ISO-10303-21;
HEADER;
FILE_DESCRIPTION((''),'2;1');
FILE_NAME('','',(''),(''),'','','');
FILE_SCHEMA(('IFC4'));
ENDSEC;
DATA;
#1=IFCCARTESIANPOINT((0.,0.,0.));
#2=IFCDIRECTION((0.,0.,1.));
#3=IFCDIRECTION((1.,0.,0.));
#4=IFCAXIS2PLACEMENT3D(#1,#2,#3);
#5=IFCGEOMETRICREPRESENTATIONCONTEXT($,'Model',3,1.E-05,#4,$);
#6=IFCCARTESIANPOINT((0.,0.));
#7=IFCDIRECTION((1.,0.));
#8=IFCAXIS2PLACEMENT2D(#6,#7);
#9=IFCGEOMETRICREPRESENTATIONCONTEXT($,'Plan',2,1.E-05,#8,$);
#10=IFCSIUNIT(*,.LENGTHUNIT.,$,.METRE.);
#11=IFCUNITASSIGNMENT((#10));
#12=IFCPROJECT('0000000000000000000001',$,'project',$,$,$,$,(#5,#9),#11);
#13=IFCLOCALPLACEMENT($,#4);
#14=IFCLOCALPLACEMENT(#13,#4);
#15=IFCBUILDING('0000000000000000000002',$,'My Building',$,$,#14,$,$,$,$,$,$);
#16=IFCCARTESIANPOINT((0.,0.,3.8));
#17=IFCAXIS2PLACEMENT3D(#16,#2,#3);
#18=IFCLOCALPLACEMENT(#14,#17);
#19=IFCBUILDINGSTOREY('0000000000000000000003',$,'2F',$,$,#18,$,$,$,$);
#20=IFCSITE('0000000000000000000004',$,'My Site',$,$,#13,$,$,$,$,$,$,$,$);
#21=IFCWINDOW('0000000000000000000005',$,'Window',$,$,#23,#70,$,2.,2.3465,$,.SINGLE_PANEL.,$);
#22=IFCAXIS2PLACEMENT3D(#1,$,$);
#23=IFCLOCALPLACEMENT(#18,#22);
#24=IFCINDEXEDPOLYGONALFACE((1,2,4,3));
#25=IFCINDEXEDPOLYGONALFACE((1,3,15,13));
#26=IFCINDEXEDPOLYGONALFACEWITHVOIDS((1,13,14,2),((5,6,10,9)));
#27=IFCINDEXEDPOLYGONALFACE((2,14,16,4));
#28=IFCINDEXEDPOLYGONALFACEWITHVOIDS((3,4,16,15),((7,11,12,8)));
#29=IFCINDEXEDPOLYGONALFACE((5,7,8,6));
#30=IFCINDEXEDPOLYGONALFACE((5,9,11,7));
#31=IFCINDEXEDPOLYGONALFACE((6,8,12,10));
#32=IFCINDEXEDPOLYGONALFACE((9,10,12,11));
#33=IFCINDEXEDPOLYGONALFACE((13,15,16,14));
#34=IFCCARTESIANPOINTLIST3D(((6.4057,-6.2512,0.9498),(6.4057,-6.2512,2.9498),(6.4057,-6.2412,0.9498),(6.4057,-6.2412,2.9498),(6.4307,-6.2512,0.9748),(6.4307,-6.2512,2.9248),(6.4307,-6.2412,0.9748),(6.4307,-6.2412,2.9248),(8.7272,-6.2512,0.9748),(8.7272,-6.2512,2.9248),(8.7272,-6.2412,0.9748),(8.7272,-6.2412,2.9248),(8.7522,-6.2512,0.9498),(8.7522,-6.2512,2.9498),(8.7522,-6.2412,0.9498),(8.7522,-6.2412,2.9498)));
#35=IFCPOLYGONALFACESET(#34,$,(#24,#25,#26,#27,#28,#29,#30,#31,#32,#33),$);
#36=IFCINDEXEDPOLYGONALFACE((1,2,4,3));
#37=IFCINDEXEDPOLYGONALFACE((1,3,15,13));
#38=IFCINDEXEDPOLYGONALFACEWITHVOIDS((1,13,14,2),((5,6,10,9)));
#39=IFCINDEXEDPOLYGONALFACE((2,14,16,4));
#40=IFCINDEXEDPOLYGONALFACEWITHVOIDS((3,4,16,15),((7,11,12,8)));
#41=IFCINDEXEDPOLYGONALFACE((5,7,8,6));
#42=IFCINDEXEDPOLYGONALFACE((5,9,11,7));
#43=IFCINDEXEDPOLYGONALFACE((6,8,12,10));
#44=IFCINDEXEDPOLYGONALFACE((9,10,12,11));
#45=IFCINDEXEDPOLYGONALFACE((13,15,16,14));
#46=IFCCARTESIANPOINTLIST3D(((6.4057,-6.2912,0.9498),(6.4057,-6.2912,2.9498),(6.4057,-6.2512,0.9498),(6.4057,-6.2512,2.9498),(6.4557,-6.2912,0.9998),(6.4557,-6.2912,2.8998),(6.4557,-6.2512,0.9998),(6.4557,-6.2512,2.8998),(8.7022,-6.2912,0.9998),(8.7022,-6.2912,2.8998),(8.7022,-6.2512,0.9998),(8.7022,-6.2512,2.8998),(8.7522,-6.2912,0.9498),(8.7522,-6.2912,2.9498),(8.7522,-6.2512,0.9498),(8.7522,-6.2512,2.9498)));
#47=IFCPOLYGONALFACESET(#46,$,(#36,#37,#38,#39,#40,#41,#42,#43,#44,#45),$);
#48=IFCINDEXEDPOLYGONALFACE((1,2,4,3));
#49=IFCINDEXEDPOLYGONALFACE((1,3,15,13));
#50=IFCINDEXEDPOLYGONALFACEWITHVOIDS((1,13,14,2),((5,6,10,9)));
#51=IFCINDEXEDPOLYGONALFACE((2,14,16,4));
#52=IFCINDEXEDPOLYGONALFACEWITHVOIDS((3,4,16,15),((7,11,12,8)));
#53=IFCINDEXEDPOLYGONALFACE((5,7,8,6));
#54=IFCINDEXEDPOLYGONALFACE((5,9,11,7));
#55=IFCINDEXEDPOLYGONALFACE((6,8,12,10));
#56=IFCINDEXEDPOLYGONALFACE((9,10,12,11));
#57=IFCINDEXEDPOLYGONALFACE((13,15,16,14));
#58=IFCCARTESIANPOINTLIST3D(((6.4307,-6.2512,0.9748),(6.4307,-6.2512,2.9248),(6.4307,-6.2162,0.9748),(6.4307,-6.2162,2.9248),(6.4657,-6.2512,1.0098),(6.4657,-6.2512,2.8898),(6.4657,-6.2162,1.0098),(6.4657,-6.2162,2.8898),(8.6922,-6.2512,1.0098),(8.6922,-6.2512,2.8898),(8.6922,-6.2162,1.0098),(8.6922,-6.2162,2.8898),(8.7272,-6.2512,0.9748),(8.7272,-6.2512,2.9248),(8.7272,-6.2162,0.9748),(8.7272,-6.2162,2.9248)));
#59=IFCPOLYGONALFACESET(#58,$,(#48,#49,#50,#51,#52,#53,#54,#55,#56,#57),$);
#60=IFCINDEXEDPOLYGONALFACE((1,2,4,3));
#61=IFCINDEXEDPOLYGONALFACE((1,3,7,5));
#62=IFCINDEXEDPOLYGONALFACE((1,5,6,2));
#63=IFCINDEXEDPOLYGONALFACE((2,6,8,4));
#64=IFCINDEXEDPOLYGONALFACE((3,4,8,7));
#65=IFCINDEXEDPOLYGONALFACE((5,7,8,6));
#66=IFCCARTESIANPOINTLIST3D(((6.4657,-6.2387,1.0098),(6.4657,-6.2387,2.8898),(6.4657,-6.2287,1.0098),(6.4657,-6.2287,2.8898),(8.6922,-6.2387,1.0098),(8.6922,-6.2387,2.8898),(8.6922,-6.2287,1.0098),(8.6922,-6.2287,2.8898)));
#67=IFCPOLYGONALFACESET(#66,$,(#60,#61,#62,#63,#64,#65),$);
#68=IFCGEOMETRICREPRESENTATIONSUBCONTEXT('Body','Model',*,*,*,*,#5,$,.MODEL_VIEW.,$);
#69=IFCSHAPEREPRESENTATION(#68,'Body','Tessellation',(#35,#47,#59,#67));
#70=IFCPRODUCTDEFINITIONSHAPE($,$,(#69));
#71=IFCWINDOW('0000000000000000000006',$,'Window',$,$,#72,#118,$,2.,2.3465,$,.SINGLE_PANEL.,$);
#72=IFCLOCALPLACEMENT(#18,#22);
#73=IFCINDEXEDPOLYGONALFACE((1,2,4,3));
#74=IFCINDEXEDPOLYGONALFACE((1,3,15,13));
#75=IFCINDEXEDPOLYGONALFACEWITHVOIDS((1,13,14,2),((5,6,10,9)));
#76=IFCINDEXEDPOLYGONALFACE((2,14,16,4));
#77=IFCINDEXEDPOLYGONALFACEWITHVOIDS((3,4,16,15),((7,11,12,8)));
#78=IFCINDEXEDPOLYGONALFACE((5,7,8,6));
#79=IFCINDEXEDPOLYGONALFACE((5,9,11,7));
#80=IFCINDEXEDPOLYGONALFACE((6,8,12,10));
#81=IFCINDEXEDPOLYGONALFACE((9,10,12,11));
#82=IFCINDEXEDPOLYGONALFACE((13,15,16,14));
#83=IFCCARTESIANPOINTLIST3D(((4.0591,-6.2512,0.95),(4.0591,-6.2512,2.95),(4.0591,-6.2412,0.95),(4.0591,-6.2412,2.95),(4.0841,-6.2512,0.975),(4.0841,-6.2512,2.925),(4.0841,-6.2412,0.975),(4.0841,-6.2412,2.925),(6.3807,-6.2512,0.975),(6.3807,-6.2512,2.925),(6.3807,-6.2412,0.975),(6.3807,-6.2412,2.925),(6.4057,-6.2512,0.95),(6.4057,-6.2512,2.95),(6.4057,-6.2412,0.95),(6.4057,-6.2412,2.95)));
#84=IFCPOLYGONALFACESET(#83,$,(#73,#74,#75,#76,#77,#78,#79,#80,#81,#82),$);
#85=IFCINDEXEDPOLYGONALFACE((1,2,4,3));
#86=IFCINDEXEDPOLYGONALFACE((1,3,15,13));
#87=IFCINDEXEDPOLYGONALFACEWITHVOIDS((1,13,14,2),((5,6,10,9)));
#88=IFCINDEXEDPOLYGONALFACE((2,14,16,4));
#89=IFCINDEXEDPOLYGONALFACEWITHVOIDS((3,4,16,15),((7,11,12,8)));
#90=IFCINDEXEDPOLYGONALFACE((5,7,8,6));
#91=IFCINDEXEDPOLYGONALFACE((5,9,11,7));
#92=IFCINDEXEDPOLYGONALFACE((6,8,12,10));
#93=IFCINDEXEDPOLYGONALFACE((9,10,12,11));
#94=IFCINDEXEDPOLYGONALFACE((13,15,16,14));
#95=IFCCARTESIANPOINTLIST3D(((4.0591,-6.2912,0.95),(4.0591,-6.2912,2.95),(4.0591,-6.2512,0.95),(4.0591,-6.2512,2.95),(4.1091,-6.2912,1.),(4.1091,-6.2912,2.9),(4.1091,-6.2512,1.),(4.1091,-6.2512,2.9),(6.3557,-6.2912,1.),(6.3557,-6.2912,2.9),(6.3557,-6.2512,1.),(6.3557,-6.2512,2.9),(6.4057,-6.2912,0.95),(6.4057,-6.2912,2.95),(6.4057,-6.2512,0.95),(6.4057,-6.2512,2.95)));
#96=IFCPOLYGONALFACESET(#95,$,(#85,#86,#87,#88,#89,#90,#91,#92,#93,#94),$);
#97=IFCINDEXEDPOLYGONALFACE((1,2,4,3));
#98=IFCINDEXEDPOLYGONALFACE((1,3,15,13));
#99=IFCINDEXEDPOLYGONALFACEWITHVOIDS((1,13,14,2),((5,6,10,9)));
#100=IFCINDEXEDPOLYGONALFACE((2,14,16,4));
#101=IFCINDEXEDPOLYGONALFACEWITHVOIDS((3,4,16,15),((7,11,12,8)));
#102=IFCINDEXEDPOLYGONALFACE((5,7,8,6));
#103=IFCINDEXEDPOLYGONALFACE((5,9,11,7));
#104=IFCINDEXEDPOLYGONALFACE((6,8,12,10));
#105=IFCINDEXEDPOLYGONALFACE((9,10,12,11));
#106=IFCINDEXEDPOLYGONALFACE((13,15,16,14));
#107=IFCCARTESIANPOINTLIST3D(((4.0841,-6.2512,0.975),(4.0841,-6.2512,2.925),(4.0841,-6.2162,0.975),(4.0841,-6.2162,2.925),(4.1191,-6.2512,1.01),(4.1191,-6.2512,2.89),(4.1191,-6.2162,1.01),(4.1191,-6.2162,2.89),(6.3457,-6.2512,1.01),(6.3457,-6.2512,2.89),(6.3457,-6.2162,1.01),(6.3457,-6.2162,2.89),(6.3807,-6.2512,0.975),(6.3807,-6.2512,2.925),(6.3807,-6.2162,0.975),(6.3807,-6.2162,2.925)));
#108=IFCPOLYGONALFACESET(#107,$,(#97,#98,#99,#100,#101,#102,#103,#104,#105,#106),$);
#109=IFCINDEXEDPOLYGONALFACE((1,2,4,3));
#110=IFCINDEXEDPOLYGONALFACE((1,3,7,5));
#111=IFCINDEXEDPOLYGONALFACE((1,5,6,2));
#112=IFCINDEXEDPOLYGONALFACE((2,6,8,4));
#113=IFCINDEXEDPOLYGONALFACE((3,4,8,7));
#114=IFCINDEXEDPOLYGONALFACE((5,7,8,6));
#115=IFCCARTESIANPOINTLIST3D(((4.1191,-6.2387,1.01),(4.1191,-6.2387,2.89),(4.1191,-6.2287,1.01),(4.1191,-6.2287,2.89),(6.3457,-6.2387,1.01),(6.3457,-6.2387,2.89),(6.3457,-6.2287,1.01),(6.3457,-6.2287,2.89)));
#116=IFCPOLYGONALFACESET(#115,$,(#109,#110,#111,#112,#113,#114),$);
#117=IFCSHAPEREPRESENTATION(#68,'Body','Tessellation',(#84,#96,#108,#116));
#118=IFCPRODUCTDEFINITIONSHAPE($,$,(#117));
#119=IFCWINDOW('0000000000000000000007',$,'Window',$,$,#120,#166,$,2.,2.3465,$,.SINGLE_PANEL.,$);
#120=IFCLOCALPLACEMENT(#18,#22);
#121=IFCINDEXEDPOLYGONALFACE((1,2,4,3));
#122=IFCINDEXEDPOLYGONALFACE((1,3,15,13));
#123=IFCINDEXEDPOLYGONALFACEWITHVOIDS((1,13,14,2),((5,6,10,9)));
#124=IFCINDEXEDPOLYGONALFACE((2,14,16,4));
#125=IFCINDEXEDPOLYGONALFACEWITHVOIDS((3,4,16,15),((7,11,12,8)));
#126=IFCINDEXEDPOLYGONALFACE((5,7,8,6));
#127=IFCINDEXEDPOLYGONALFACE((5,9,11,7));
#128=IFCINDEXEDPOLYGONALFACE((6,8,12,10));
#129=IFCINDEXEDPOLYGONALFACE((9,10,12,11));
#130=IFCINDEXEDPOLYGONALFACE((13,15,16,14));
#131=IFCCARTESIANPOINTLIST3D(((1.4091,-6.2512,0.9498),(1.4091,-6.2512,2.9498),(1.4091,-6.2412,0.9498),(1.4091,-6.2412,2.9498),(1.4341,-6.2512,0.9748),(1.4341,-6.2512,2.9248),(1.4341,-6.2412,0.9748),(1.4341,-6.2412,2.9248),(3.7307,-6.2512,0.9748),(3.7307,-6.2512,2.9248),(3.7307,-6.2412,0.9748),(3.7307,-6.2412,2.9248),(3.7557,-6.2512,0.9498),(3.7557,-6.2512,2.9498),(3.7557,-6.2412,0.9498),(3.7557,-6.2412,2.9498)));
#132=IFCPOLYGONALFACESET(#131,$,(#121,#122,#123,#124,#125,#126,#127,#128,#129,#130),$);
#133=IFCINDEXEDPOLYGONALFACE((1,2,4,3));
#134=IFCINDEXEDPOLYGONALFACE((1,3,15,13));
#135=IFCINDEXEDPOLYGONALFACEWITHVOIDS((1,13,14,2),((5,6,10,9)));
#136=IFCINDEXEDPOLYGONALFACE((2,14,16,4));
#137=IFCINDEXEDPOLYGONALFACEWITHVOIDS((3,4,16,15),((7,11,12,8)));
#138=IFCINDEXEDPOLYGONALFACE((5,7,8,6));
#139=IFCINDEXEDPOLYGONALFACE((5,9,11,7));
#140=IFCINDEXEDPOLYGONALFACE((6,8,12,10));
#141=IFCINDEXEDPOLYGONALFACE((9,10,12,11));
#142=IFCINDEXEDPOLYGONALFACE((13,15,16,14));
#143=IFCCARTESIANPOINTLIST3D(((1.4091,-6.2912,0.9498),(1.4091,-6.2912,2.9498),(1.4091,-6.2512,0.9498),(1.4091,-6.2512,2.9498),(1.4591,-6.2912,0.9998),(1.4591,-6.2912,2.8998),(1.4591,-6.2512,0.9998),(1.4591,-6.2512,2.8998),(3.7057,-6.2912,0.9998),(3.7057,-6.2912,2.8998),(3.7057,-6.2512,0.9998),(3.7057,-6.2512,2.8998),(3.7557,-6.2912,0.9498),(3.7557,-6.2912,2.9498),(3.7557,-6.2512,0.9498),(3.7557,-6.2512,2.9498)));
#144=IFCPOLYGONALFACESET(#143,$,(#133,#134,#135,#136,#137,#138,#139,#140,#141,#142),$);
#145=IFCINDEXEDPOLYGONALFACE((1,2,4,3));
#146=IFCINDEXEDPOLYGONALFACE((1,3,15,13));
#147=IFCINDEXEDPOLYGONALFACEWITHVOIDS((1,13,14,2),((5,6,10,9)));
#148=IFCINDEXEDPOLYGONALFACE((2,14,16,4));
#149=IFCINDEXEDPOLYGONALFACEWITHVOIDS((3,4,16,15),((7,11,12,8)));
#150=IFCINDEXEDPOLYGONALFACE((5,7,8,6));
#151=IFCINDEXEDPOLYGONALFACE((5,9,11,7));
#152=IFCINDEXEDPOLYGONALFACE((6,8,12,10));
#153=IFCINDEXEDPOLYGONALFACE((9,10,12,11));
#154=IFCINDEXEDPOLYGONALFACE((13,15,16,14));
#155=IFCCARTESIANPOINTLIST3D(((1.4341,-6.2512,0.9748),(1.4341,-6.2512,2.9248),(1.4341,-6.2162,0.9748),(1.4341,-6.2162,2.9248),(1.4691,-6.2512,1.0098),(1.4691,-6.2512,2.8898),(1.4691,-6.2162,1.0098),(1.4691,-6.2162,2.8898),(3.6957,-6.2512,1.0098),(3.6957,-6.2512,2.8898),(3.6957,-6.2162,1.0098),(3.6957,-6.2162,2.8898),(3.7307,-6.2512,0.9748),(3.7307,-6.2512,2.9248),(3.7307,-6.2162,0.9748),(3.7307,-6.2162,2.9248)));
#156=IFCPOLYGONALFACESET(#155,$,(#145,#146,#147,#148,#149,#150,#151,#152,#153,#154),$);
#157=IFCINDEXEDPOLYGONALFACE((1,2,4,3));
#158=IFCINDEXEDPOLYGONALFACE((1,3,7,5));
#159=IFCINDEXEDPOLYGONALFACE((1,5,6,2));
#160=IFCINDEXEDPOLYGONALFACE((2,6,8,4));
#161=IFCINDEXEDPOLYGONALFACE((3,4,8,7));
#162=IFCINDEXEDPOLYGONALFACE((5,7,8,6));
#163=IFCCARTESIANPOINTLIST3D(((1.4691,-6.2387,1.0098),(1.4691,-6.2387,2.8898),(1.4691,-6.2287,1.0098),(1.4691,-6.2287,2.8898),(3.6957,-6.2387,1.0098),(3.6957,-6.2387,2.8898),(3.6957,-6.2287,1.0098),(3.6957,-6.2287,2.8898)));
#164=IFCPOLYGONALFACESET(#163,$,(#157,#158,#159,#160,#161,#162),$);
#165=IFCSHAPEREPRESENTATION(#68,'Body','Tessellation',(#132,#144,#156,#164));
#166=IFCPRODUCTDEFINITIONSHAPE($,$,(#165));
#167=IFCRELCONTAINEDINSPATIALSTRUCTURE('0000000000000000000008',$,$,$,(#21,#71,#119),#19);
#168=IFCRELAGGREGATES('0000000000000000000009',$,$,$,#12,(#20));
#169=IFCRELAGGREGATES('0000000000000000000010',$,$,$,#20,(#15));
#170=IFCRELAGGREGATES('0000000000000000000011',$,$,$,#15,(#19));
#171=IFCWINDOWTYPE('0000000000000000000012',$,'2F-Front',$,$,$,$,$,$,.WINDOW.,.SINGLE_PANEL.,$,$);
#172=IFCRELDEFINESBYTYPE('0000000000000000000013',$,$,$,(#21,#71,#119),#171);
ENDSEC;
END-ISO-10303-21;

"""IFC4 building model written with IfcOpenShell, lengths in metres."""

from ifc_helpers import new_model, entity, si_unit, frame, origin_with_axes, origin_2d_with_axis, place, context, subcontext, project, spatial, line, indexed_curve, outline, extrude, shape, source, transform, mapped, type_object, type_shapes, element, save


model = new_model("IFC4")

# Units and contexts
model_context = context("Model", 3, precision=1e-05, world=origin_with_axes())
plan_context = context("Plan", 2, precision=1e-05, world=origin_2d_with_axis())
body_context_1 = subcontext(model_context, "Body", "Model", "MODEL_VIEW")
body_context_2 = subcontext(plan_context, "Body", "Plan", "PLAN_VIEW")
ifc_project = project(units=[si_unit("LENGTHUNIT", "METRE")], contexts=[model_context, plan_context])

# Site, building, storey
site_placement = place(None, origin_with_axes())
site = spatial("IfcSite", under=ifc_project, at=site_placement, Name="My Site")
building_placement = place(site_placement, origin_with_axes())
building = spatial("IfcBuilding", under=site, at=building_placement, Name="My Building")
storey_placement = place(building_placement, frame((0.0, 0.0, 3.8), z_axis=(0.0, 0.0, 1.0), x_axis=(1.0, 0.0, 0.0)))
storey = spatial("IfcBuildingStorey", under=building, at=storey_placement, Name="2F")

# Windows
window_type_1 = type_object("IfcWindowType", Name="2F-Front", PartitioningType="SINGLE_PANEL", PredefinedType="WINDOW")
shared_shape_1 = source(origin_with_axes(), body_context_1, "Body", "SweptSolid", [
    extrude(outline(indexed_curve([(0.0, 0.0), (2.3465, 0.0), (2.3465, 2.0), (0.0, 2.0)], segments=[line(1, 2, 3, 4, 1)]), holes=[indexed_curve([(0.025, 0.025), (2.3215, 0.025), (2.3215, 1.975), (0.025, 1.975)], segments=[line(1, 2, 3, 4, 1)])]), frame((0.0, 0.09, 0.0), z_axis=(0.0, -1.0, 0.0), x_axis=(1.0, 0.0, 0.0)), (0.0, 0.0, -1.0), 0.01),
    extrude(outline(indexed_curve([(0.0, 0.0), (2.3465, 0.0), (2.3465, 2.0), (0.0, 2.0)], segments=[line(1, 2, 3, 4, 1)]), holes=[indexed_curve([(0.05, 0.05), (2.2965, 0.05), (2.2965, 1.95), (0.05, 1.95)], segments=[line(1, 2, 3, 4, 1)])]), frame((0.0, 0.05, 0.0), z_axis=(0.0, -1.0, 0.0), x_axis=(1.0, 0.0, 0.0)), (0.0, 0.0, -1.0), 0.04),
    extrude(outline(indexed_curve([(0.0, 0.0), (2.2965, 0.0), (2.2965, 1.95), (0.0, 1.95)], segments=[line(1, 2, 3, 4, 1)]), holes=[indexed_curve([(0.035, 0.035), (2.2615, 0.035), (2.2615, 1.915), (0.035, 1.915)], segments=[line(1, 2, 3, 4, 1)])]), frame((0.025, 0.09, 0.025), z_axis=(0.0, -1.0, 0.0), x_axis=(1.0, 0.0, 0.0)), (0.0, 0.0, -1.0), 0.035),
    extrude(outline(indexed_curve([(0.035, 0.035), (2.2615, 0.035), (2.2615, 1.915), (0.035, 1.915)], segments=[line(1, 2, 3, 4, 1)])), frame((0.025, 0.1025, 0.025), z_axis=(0.0, -1.0, 0.0), x_axis=(1.0, 0.0, 0.0)), (0.0, 0.0, -1.0), 0.01),
])
shared_shape_2 = source(origin_with_axes(), body_context_2, "Body", "Curve2D", [
    entity("IfcIndexedPolyCurve", entity("IfcCartesianPointList2D", [[0.05, 0.05], [2.2965, 0.05]])),
    entity("IfcIndexedPolyCurve", entity("IfcCartesianPointList2D", [[0.0, 0.1], [0.025, 0.1], [0.025, 0.09], [0.05, 0.09], [0.05, 0.05], [0.0, 0.05]]), [entity("IfcLineIndex", [1, 2, 3, 4, 5, 6, 1])]),
    entity("IfcIndexedPolyCurve", entity("IfcCartesianPointList2D", [[2.3465, 0.1], [2.3215, 0.1], [2.3215, 0.09], [2.2965, 0.09], [2.2965, 0.05], [2.3465, 0.05]]), [entity("IfcLineIndex", [1, 2, 3, 4, 5, 6, 1])]),
    entity("IfcIndexedPolyCurve", entity("IfcCartesianPointList2D", [[0.025, 0.09], [0.06, 0.09], [0.06, 0.125], [0.025, 0.125]]), [entity("IfcLineIndex", [1, 2, 3, 4, 1])]),
    entity("IfcIndexedPolyCurve", entity("IfcCartesianPointList2D", [[2.3215, 0.09], [2.2865, 0.09], [2.2865, 0.125], [2.3215, 0.125]]), [entity("IfcLineIndex", [1, 2, 3, 4, 1])]),
    entity("IfcIndexedPolyCurve", entity("IfcCartesianPointList2D", [[0.06, 0.09], [2.2865, 0.09]])),
    entity("IfcIndexedPolyCurve", entity("IfcCartesianPointList2D", [[0.06, 0.125], [2.2865, 0.125]])),
    entity("IfcIndexedPolyCurve", entity("IfcCartesianPointList2D", [[0.06, 0.1075], [2.2865, 0.1075]])),
])
type_shapes(window_type_1, [shared_shape_1, shared_shape_2])
for number, where, z_axis, x_axis, name in (
    (1, (6.4057, -6.3412, 0.9498), (0.0, 0.0, 1.0), (1.0, 0.0, 0.0), "Window"),
    (2, (4.0591, -6.3412, 0.95), (0.0, 0.0, 1.0), (1.0, 0.0, 0.0), "Window"),
    (3, (1.4091, -6.3412, 0.9498), (0.0, 0.0, 1.0), (1.0, 0.0, 0.0), "Window"),
):
    element("IfcWindow", number, at=place(storey_placement, frame(where, z_axis=z_axis, x_axis=x_axis)), inside=storey, type_object=window_type_1, Name=name, OverallHeight=2.0, OverallWidth=2.3465, PartitioningType="SINGLE_PANEL", shapes=[
        shape(body_context_1, "Body", "MappedRepresentation", [mapped(shared_shape_1, transform((0.0, 0.0, 0.0), x_axis=(1.0, 0.0, 0.0), y_axis=(0.0, 1.0, 0.0), z_axis=(0.0, 0.0, 1.0), scale=1.0))]),
        shape(body_context_2, "Body", "MappedRepresentation", [mapped(shared_shape_2, transform((0.0, 0.0, 0.0), x_axis=(1.0, 0.0, 0.0), y_axis=(0.0, 1.0, 0.0), z_axis=(0.0, 0.0, 1.0), scale=1.0))]),
    ])

save(model, "model.ifc")
